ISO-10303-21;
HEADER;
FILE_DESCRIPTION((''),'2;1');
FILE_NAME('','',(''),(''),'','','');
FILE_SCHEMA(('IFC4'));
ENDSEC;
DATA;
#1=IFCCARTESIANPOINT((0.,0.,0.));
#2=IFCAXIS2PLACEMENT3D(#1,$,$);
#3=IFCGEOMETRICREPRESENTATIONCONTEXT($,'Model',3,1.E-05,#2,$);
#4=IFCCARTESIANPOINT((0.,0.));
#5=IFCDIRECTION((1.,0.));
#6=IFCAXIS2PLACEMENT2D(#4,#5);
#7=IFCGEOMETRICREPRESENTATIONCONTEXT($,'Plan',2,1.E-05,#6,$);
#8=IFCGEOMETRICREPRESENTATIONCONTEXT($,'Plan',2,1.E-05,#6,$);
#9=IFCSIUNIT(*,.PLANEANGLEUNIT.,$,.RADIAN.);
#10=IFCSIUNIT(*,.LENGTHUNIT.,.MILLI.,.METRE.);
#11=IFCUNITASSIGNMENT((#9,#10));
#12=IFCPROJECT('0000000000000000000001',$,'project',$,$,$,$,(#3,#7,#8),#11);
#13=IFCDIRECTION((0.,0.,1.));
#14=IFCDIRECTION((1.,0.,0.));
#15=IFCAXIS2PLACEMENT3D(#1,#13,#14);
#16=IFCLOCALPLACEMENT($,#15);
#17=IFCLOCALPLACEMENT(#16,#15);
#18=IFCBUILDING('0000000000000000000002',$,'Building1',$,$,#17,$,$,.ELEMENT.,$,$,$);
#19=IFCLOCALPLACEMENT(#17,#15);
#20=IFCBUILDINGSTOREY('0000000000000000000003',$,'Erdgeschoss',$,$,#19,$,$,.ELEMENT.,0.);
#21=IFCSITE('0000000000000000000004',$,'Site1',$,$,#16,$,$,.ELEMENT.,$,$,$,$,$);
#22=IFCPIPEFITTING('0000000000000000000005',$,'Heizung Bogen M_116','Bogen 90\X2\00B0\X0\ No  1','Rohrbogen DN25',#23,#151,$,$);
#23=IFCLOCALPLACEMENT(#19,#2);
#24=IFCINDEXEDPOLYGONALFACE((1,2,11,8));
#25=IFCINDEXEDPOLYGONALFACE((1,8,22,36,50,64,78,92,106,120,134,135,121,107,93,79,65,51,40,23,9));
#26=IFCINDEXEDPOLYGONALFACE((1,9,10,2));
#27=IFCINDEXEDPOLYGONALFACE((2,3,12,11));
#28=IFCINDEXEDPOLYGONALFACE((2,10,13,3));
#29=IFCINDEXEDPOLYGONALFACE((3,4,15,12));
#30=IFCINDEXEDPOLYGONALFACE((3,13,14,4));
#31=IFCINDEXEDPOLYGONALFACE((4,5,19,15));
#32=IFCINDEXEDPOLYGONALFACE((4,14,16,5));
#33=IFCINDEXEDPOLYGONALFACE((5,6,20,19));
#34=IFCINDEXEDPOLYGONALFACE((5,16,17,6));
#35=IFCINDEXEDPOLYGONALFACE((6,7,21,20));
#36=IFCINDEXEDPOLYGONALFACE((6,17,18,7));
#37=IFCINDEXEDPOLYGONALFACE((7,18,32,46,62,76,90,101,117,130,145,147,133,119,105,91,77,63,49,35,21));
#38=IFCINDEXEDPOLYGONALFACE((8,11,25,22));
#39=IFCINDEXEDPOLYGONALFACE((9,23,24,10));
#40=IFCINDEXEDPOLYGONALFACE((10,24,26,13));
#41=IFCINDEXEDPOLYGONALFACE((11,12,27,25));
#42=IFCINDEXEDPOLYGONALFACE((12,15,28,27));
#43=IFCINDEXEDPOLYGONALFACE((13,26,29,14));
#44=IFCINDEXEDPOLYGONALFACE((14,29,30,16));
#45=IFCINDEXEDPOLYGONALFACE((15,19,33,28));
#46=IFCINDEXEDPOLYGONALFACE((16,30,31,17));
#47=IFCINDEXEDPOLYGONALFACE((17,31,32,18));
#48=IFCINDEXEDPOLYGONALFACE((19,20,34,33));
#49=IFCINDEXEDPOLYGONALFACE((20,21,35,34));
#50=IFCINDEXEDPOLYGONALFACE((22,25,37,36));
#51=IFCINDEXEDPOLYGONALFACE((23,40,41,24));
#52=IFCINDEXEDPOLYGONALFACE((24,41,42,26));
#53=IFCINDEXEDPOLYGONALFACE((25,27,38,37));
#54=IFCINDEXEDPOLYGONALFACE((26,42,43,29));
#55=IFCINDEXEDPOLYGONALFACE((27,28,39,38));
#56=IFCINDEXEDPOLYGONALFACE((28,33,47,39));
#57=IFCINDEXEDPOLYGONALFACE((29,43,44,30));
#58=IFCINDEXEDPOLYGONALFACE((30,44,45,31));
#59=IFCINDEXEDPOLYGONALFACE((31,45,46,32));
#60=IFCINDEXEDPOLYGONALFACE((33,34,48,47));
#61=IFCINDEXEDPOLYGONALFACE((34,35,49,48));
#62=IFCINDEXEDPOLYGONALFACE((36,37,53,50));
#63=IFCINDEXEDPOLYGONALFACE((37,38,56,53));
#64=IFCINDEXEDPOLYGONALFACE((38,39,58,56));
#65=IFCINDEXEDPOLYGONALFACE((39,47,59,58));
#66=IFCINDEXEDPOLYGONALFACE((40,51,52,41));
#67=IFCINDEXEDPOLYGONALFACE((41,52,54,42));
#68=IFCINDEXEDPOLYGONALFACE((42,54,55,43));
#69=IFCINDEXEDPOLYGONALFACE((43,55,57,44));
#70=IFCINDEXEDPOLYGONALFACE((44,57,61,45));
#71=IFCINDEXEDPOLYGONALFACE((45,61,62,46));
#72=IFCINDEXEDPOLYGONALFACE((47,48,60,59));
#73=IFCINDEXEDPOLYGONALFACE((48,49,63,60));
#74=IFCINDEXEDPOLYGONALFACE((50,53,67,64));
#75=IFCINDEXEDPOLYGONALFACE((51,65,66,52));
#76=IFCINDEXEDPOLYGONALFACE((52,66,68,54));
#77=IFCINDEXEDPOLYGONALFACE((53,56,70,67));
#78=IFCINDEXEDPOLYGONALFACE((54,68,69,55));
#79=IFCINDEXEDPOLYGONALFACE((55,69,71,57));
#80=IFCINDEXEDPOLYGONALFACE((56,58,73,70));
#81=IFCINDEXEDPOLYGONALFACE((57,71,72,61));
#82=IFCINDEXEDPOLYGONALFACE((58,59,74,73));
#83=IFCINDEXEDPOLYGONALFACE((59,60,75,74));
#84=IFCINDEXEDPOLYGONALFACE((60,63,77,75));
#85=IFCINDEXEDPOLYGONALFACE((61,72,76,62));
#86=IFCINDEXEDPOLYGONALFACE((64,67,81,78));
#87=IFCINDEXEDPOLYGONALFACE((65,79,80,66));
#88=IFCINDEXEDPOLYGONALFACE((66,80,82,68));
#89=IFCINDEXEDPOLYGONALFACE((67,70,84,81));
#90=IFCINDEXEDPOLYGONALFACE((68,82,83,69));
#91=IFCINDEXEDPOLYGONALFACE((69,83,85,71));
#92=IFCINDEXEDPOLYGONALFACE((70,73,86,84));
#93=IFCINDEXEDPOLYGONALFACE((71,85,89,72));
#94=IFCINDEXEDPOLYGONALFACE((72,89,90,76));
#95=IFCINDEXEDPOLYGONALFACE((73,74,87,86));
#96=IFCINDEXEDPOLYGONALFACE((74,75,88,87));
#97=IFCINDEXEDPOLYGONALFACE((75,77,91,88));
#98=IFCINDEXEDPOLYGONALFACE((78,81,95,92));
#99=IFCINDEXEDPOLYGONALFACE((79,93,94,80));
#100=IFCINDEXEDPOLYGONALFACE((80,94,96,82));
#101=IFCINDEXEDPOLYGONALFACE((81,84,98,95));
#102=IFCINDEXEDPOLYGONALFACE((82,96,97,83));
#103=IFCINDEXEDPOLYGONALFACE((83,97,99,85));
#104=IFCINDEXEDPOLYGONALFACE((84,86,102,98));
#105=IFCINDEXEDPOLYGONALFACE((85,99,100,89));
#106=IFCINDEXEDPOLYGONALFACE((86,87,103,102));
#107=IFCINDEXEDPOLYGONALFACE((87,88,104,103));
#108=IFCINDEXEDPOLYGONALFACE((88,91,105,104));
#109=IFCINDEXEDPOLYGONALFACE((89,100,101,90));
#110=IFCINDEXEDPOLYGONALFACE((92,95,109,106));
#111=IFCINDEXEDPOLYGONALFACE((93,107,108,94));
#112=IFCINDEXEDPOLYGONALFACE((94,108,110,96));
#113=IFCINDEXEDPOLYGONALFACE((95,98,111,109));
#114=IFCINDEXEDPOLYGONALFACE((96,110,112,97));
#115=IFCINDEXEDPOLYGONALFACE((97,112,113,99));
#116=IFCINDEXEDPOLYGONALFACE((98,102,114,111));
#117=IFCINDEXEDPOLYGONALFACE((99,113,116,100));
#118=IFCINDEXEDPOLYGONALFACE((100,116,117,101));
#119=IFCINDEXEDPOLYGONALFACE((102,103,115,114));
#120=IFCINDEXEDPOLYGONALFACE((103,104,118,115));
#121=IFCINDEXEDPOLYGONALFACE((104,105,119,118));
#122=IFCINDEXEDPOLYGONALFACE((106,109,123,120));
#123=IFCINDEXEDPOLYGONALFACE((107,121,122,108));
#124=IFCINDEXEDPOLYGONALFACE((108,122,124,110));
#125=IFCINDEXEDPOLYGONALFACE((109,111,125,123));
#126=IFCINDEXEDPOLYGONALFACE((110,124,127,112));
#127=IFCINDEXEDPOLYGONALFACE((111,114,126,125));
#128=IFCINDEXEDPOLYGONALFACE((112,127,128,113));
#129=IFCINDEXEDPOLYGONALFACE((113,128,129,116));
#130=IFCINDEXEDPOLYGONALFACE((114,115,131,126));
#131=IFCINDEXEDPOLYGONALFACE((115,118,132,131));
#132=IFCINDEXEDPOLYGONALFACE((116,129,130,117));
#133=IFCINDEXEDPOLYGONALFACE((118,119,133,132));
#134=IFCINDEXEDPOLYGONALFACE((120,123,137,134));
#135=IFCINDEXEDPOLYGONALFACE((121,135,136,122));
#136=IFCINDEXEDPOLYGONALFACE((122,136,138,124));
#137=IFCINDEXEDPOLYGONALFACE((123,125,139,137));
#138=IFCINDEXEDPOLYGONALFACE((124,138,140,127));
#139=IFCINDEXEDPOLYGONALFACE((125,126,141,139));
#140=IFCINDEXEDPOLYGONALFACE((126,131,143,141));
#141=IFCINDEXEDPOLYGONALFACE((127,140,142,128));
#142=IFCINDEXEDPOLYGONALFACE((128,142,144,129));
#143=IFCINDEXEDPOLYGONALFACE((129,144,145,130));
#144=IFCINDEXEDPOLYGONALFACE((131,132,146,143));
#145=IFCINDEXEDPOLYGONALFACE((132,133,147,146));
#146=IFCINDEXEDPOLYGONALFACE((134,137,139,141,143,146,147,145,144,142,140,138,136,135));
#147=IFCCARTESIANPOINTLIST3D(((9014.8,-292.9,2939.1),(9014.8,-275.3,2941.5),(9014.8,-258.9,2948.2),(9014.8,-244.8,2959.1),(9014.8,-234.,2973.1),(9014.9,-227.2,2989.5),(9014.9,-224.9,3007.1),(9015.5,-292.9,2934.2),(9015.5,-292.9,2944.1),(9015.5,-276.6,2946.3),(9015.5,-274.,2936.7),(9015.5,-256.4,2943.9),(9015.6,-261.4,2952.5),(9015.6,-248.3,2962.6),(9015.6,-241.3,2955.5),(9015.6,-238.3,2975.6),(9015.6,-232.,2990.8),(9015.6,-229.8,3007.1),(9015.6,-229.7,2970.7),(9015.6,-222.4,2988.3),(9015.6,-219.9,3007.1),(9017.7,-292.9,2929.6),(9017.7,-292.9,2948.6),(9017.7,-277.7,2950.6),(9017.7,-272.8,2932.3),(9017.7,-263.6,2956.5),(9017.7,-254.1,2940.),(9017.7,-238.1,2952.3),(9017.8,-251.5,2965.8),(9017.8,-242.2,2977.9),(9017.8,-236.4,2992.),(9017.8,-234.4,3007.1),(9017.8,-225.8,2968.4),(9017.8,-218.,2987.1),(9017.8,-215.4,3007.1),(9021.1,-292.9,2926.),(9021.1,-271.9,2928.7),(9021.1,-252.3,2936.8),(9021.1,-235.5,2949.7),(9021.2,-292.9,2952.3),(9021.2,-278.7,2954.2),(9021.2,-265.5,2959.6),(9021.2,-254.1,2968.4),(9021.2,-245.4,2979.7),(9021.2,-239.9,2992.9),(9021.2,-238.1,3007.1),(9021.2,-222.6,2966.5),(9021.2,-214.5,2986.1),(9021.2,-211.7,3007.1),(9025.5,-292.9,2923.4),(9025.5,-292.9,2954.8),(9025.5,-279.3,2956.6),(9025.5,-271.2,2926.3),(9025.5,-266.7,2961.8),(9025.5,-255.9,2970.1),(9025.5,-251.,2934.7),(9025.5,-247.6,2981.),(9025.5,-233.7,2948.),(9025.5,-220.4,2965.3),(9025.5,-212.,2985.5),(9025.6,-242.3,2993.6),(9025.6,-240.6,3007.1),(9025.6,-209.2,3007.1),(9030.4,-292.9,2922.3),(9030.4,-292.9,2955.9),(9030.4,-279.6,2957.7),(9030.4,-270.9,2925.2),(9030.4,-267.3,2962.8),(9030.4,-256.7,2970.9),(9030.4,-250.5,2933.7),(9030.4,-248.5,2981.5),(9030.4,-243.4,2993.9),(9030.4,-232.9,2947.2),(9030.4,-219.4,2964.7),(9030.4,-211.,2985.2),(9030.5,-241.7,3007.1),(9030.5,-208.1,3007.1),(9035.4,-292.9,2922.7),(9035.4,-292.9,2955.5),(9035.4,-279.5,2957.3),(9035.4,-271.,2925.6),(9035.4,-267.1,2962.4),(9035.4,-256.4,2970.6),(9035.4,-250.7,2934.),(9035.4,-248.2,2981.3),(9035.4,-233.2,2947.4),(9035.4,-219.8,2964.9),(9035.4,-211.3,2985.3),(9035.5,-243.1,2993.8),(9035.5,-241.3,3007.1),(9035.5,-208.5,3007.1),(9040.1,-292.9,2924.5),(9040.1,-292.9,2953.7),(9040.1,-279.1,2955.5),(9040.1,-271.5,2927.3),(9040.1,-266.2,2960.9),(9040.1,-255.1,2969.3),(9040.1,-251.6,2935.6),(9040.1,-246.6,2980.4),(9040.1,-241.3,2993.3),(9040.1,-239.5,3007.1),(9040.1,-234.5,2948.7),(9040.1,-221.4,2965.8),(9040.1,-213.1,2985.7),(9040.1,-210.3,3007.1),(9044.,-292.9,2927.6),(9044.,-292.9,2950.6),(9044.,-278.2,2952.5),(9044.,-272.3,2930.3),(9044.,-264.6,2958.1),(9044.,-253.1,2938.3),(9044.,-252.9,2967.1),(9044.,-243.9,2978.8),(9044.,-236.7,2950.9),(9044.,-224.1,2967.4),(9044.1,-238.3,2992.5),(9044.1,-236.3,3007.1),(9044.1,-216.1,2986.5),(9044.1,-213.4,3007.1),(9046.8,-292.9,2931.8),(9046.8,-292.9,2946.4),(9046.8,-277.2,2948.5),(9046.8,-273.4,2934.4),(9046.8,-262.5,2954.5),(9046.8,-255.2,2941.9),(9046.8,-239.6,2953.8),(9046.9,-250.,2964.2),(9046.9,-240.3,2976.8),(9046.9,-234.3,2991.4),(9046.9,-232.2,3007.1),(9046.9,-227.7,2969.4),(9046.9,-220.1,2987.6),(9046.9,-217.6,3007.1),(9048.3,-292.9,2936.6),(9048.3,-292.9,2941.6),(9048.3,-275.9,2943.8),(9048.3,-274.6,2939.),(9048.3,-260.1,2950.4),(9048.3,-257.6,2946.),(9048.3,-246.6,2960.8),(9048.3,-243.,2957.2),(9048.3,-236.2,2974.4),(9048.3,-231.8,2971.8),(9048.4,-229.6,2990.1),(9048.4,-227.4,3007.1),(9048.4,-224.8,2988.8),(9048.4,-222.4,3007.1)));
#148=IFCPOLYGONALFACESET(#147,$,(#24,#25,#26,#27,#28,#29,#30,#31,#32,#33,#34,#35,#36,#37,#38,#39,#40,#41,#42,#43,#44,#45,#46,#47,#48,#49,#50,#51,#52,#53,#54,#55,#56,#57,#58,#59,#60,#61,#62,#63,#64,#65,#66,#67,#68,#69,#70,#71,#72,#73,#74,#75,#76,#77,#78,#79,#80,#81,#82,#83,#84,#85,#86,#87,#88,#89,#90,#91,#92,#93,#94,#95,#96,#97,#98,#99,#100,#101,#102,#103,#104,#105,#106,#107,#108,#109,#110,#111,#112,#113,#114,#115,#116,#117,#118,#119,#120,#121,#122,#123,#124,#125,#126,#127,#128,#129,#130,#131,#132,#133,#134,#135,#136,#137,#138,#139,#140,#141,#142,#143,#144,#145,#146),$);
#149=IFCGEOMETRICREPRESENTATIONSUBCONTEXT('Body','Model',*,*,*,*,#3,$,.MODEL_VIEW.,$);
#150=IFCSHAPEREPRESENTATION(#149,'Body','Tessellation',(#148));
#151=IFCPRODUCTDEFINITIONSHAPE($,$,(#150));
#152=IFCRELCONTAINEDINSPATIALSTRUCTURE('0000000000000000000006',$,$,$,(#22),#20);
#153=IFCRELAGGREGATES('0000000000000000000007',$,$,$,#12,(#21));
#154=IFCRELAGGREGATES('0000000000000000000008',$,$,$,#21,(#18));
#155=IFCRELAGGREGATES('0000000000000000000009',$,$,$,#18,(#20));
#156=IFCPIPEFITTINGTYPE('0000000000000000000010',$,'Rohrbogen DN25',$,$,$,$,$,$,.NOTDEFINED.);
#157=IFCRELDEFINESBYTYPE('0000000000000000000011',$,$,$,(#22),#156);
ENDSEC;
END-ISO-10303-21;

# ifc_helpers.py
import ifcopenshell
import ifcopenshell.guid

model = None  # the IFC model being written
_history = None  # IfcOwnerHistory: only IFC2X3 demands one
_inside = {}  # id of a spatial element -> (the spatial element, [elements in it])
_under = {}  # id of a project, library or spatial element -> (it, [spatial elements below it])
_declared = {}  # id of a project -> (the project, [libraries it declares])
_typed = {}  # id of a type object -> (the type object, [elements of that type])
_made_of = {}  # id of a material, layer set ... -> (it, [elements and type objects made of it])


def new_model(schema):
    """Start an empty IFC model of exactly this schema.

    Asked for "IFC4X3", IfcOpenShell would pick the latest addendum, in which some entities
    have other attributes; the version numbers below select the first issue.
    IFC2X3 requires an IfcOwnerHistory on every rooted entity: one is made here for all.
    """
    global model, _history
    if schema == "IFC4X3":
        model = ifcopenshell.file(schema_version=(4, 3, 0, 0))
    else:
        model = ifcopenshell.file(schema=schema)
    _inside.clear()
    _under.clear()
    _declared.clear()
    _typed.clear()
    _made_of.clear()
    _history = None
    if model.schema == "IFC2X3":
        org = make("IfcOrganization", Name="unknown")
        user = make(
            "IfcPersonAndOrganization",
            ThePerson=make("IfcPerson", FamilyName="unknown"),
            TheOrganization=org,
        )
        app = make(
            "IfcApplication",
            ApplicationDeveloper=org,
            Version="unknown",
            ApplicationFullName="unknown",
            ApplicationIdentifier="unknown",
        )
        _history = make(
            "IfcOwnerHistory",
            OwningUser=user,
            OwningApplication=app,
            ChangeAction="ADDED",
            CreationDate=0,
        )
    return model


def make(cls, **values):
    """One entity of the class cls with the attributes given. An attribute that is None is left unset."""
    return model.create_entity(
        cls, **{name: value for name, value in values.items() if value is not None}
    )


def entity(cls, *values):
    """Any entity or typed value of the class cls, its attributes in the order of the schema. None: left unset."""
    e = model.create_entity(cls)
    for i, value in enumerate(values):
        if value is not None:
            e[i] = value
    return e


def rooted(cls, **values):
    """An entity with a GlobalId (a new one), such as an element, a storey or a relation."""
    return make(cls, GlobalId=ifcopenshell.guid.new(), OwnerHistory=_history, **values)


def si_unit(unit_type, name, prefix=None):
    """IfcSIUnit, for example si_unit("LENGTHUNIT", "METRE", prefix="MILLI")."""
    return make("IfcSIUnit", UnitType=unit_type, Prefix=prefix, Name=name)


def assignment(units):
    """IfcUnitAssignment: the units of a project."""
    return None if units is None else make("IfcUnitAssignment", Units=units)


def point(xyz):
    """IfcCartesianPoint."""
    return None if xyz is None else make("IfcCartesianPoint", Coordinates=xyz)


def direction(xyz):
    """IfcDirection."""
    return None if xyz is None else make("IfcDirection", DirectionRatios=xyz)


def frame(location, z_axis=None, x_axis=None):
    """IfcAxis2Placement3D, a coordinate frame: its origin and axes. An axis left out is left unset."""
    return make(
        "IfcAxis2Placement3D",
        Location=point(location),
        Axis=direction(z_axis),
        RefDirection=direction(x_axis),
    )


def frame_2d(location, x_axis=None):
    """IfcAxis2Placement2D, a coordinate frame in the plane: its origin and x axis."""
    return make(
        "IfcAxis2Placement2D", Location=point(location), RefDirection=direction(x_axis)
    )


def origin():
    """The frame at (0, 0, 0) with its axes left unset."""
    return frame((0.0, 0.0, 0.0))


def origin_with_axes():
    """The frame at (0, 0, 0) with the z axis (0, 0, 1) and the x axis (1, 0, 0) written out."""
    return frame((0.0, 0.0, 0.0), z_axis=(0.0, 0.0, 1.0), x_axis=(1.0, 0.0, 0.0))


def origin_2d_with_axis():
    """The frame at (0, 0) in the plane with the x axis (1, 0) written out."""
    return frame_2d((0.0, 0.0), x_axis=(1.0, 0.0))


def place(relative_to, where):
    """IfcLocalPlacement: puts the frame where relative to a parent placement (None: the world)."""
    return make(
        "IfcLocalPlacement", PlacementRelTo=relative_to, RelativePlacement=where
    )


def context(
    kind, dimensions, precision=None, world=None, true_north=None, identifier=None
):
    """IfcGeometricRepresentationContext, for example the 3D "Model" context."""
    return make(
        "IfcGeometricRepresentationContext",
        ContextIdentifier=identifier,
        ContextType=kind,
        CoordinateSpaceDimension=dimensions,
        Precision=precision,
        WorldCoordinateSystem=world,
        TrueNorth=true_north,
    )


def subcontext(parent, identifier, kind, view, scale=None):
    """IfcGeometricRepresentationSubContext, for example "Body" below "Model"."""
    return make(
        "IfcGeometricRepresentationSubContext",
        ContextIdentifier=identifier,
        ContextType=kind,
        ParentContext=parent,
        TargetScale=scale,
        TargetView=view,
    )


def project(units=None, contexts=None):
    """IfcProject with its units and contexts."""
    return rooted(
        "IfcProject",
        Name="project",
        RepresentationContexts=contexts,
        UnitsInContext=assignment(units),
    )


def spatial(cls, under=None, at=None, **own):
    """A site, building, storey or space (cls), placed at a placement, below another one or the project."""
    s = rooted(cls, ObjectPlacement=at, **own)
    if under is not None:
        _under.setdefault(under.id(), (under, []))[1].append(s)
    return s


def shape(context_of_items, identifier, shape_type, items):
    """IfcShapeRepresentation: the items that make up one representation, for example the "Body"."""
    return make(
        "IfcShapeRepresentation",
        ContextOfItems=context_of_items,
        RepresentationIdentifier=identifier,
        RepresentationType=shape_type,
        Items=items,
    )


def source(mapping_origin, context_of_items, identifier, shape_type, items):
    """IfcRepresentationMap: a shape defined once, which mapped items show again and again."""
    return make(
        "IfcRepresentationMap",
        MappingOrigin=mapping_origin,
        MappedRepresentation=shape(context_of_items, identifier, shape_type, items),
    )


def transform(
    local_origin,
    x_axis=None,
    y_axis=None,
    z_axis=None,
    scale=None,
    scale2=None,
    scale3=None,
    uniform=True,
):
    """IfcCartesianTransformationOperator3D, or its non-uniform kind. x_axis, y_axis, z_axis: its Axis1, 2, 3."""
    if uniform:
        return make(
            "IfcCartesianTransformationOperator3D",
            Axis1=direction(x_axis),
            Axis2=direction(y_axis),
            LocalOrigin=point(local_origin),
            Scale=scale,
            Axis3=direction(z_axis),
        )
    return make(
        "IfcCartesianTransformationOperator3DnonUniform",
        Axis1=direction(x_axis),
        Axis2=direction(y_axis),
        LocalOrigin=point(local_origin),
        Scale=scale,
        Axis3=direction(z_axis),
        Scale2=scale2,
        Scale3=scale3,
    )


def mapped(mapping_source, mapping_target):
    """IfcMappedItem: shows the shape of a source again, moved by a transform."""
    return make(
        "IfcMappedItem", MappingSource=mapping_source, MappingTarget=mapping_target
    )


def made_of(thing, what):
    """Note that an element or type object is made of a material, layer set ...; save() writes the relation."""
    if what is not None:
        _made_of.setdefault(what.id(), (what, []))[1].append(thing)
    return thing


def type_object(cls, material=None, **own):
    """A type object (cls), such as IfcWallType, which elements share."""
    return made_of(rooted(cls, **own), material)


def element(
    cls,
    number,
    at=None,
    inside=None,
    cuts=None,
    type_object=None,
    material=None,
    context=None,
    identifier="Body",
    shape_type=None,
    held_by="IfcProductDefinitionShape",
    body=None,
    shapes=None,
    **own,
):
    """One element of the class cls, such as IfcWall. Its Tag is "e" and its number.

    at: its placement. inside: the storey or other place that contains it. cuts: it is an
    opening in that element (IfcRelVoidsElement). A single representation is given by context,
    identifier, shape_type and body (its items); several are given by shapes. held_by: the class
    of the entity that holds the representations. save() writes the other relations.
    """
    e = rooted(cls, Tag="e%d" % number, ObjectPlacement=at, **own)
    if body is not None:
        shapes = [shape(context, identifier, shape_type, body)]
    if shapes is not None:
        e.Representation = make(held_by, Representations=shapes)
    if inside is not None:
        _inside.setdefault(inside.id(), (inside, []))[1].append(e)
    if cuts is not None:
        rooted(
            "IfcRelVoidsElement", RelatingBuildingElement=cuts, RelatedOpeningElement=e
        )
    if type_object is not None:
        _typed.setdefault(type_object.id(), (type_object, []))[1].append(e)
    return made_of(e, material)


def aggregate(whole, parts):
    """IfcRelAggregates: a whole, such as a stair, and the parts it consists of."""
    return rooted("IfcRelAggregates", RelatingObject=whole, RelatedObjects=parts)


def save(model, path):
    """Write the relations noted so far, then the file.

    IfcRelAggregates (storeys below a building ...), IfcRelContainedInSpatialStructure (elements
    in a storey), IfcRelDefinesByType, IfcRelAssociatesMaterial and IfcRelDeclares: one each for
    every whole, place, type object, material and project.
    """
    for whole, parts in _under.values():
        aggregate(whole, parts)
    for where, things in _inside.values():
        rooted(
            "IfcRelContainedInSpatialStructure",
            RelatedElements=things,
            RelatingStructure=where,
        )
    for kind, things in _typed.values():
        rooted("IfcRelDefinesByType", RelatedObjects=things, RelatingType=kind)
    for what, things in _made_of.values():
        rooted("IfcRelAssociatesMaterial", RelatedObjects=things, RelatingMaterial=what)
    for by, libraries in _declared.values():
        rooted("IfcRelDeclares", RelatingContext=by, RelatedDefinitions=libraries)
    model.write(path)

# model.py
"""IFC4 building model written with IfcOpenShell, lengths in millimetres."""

from ifc_helpers import new_model, entity, si_unit, frame, origin, origin_with_axes, origin_2d_with_axis, place, context, subcontext, project, spatial, source, transform, mapped, type_object, element, save


model = new_model("IFC4")

# Units and contexts
model_context = context("Model", 3, precision=1e-05, world=origin())
plan_context_1 = context("Plan", 2, precision=1e-05, world=origin_2d_with_axis())
plan_context_2 = context("Plan", 2, precision=1e-05, world=origin_2d_with_axis())
body_context = subcontext(model_context, "Body", "Model", "MODEL_VIEW")
ifc_project = project(units=[si_unit("PLANEANGLEUNIT", "RADIAN"), si_unit("LENGTHUNIT", "METRE", prefix="MILLI")], contexts=[model_context, plan_context_1, plan_context_2])

# Site, building, storey
site_placement = place(None, origin_with_axes())
site = spatial("IfcSite", under=ifc_project, at=site_placement, Name="Site1", CompositionType="ELEMENT")
building_placement = place(site_placement, origin_with_axes())
building = spatial("IfcBuilding", under=site, at=building_placement, Name="Building1", CompositionType="ELEMENT")
storey_placement = place(building_placement, origin_with_axes())
storey = spatial("IfcBuildingStorey", under=building, at=storey_placement, Name="Erdgeschoss", CompositionType="ELEMENT", Elevation=0.0)

# Shared definitions
pipe_fitting_type_1 = type_object("IfcPipeFittingType", Name="Rohrbogen DN25", PredefinedType="NOTDEFINED")

# Pipe fitting
shared_shape_1 = source(origin_with_axes(), body_context, "Body", "SolidModel", [
    entity("IfcRevolvedAreaSolid", entity("IfcCircleProfileDef", "AREA", None, entity("IfcAxis2Placement2D", entity("IfcCartesianPoint", [0.0, 0.0]), entity("IfcDirection", [1.0, 0.0])), 16.9), entity("IfcAxis2Placement3D", entity("IfcCartesianPoint", [-42.4, 0.0, -25.6]), entity("IfcDirection", [1.0, 0.0, 0.0]), entity("IfcDirection", [0.0, 0.999999, 0.001207])), entity("IfcAxis1Placement", entity("IfcCartesianPoint", [0.0, 68.0, 0.0]), entity("IfcDirection", [-1.0, 0.0, 0.0])), 1.570796),
])
pipe_fitting_1_placement = place(storey_placement, frame((9031.7, -250.5, 2964.7), z_axis=(0.0, 0.0, 1.0), x_axis=(1.0, 0.0, 0.0)))
element("IfcPipeFitting", 1, at=pipe_fitting_1_placement, inside=storey, type_object=pipe_fitting_type_1, Name="Heizung Bogen M_116", Description="Bogen 90° No  1", ObjectType="Rohrbogen DN25", context=body_context, shape_type="MappedRepresentation", body=[
    mapped(shared_shape_1, transform((0.0, 0.0, 0.0), x_axis=(0.0, 1.0, 0.0), y_axis=(-1.0, 0.0, 0.0), z_axis=(0.0, 0.0, 1.0), scale=1.0)),
])

save(model, "model.ifc")
